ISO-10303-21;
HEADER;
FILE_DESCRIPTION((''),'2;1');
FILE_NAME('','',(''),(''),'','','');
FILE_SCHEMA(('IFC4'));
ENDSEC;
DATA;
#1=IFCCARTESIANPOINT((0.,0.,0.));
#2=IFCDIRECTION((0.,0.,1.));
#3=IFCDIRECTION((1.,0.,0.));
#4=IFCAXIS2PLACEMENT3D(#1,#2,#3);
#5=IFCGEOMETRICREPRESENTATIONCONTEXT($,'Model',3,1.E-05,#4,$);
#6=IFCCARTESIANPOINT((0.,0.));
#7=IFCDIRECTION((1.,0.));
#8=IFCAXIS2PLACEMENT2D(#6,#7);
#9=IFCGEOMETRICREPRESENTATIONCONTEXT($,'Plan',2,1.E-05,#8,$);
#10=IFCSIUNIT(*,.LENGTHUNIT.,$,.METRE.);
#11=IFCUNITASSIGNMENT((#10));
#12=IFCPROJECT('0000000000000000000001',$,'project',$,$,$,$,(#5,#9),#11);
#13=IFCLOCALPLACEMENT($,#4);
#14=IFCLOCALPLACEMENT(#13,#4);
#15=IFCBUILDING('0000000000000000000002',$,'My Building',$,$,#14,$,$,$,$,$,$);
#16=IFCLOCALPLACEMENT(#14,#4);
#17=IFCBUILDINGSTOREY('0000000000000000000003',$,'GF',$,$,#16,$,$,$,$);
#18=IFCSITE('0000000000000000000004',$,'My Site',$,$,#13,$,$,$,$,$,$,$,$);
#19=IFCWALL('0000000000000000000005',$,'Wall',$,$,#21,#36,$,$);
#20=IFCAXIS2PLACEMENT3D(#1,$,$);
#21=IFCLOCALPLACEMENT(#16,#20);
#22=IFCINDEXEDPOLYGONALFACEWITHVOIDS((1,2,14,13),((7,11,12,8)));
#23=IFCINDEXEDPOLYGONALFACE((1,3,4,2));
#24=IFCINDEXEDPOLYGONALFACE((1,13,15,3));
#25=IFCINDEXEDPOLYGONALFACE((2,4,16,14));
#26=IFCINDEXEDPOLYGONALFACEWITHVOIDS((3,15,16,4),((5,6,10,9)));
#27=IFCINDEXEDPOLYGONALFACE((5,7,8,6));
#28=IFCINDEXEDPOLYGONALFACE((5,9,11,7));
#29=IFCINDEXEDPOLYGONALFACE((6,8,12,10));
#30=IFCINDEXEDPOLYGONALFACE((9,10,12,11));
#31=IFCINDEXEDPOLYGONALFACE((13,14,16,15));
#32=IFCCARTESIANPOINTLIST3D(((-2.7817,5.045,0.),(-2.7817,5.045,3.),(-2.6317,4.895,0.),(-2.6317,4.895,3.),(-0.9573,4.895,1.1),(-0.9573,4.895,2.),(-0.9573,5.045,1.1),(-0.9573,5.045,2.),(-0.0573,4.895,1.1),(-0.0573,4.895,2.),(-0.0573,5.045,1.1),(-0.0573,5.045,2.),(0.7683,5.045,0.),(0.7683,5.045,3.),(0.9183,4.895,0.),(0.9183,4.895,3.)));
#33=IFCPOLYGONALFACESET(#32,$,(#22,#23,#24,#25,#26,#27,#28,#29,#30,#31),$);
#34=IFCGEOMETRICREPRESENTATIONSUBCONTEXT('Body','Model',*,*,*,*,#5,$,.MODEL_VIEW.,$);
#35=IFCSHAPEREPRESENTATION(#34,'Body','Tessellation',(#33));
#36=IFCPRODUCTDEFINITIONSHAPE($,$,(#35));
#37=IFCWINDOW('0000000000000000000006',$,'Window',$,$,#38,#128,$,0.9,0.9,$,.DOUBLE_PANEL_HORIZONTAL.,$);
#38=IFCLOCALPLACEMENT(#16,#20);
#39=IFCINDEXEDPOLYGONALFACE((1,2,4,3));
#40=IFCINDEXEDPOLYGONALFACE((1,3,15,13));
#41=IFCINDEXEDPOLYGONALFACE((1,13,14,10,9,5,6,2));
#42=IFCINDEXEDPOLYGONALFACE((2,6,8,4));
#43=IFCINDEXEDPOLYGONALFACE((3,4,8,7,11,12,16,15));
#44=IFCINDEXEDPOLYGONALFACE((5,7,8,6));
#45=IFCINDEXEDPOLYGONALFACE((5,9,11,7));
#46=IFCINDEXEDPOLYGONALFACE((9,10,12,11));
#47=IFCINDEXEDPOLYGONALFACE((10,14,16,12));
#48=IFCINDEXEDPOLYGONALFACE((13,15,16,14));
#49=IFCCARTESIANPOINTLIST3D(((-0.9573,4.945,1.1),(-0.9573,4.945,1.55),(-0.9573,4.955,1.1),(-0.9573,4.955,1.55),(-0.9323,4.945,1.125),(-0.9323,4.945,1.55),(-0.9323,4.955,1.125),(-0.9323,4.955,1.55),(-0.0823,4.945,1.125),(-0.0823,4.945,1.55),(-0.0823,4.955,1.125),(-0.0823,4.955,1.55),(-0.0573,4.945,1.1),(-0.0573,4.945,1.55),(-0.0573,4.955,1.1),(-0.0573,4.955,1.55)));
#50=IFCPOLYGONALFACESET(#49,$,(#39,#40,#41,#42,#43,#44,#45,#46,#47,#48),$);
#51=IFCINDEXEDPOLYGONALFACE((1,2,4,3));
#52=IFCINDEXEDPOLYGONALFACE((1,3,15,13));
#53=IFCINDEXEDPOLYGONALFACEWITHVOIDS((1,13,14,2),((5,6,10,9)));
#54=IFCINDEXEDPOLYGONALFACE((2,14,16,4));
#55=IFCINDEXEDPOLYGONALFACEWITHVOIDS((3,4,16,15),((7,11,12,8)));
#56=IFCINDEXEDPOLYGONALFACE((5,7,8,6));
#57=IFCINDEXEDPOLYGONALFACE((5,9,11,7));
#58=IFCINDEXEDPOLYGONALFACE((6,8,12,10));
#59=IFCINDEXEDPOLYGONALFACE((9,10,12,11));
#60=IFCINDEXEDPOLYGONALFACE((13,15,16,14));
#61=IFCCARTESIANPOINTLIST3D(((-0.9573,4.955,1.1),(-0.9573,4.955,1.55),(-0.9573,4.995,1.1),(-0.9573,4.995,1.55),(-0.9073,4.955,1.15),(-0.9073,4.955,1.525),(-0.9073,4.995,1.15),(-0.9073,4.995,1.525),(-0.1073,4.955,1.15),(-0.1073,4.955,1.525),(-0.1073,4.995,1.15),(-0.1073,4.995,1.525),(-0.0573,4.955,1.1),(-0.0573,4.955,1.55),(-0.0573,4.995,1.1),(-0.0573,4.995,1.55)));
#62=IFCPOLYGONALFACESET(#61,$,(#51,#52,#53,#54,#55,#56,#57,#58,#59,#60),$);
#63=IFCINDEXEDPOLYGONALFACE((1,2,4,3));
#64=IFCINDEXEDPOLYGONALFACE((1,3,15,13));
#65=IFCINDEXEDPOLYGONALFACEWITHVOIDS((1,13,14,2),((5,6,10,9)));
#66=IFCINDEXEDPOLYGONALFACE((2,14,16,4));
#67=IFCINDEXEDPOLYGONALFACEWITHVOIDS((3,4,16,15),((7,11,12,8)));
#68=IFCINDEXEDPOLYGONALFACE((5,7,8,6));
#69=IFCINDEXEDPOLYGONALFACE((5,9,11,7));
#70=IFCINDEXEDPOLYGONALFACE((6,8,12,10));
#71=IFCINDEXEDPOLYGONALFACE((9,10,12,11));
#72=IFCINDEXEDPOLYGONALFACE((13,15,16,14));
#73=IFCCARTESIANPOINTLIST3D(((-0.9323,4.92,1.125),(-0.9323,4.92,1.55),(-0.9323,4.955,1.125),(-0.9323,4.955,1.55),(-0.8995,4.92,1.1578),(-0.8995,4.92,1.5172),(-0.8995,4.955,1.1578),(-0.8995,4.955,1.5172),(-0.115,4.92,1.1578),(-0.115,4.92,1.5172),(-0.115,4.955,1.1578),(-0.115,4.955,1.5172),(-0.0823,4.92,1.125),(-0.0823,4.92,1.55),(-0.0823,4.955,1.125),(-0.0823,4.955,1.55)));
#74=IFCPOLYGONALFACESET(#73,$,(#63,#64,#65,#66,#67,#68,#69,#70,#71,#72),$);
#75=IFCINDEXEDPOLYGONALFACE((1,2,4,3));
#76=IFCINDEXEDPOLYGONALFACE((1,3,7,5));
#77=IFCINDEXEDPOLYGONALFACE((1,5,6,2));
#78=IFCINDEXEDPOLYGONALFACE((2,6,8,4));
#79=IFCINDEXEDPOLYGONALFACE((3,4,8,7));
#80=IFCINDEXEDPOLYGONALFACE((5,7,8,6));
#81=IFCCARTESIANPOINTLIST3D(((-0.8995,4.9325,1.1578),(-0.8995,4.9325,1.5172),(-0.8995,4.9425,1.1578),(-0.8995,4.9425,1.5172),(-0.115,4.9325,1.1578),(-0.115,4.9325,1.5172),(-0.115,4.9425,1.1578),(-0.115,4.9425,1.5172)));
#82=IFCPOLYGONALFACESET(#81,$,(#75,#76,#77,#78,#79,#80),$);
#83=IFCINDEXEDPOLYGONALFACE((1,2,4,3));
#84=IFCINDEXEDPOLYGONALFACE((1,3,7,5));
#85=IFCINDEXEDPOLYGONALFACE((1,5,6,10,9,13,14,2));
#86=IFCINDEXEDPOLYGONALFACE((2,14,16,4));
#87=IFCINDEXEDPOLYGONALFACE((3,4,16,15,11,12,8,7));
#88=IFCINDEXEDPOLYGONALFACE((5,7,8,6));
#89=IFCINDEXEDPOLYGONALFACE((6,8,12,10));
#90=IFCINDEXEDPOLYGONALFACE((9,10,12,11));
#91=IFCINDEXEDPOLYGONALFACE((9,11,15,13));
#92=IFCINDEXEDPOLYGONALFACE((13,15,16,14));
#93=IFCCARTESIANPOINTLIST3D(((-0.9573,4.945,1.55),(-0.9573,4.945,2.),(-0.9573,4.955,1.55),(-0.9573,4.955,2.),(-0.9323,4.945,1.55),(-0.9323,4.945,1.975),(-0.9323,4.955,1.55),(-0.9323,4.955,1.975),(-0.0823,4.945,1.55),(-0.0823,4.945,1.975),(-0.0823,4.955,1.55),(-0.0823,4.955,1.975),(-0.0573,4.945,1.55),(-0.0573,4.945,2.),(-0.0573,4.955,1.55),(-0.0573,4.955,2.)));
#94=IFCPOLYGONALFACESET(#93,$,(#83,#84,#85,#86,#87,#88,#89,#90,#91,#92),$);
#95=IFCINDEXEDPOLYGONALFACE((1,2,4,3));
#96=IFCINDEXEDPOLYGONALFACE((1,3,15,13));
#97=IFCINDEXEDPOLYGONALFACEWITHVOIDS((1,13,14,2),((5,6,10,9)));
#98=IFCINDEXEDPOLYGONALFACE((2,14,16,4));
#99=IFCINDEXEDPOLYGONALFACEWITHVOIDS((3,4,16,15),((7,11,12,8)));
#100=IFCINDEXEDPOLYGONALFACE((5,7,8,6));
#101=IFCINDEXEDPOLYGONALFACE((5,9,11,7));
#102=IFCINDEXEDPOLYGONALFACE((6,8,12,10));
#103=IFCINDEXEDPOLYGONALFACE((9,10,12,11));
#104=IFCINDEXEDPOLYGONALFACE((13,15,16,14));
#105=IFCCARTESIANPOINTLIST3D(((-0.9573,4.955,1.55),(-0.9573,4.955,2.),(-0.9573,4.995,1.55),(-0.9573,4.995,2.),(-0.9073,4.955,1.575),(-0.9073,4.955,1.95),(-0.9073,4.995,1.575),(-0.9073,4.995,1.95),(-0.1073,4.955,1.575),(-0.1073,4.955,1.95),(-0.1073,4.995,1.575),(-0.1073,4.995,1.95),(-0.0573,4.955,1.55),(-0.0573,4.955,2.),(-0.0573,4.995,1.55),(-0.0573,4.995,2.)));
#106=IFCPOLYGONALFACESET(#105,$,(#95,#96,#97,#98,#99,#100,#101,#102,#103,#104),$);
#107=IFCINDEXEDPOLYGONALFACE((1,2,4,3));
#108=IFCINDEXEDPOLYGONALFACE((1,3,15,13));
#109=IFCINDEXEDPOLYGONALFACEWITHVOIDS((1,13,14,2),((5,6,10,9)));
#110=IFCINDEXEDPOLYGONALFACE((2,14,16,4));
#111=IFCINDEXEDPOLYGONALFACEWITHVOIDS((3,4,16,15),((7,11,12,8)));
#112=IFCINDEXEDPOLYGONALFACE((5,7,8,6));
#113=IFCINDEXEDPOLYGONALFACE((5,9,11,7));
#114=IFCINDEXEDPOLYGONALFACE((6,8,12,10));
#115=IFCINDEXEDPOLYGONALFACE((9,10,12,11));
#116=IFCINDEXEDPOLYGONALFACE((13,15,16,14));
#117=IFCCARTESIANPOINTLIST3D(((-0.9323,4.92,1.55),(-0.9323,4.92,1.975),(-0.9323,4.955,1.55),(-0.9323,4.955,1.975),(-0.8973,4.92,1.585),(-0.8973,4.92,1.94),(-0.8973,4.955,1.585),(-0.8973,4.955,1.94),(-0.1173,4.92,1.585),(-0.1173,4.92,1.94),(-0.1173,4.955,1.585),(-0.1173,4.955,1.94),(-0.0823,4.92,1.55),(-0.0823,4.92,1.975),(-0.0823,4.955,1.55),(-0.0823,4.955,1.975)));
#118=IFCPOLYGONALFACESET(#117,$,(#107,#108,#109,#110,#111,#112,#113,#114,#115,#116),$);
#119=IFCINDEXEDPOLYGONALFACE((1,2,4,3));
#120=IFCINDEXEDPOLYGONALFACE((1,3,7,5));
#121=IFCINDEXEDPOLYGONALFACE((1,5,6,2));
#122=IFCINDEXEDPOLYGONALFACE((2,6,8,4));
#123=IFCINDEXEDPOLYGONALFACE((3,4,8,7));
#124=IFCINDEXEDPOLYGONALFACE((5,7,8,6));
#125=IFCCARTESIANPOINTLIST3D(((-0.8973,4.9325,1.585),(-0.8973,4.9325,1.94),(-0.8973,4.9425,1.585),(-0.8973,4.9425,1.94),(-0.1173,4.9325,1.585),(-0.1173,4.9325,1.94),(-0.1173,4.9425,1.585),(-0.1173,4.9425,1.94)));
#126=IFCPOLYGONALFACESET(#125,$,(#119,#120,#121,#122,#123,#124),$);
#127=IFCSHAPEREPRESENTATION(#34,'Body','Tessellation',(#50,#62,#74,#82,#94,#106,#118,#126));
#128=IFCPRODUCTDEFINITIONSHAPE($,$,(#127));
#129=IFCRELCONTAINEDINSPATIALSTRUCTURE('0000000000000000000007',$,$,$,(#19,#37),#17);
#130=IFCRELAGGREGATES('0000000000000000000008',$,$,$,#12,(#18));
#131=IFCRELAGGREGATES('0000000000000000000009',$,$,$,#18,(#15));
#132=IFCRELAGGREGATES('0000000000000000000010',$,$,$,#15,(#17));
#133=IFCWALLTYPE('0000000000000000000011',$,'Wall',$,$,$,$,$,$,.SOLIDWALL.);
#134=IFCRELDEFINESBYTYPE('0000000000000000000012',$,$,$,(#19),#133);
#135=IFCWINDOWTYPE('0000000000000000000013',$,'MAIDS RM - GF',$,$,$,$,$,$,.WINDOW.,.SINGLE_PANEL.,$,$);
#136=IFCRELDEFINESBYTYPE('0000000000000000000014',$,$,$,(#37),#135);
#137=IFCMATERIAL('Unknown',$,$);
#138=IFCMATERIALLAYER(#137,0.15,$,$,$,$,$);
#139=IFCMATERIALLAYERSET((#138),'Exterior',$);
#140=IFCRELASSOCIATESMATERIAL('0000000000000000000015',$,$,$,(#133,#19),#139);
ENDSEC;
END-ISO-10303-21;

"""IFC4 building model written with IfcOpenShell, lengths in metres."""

from ifc_helpers import new_model, entity, si_unit, frame, origin_with_axes, origin_2d_with_axis, place, context, subcontext, project, spatial, line, indexed_curve, outline, extrude, shape, source, transform, mapped, material, layer, layer_set, layer_usage, type_object, type_shapes, element, fill, save


model = new_model("IFC4")

# Units and contexts
model_context = context("Model", 3, precision=1e-05, world=origin_with_axes())
plan_context = context("Plan", 2, precision=1e-05, world=origin_2d_with_axis())
body_context_1 = subcontext(model_context, "Body", "Model", "MODEL_VIEW")
body_context_2 = subcontext(plan_context, "Body", "Plan", "PLAN_VIEW")
ifc_project = project(units=[si_unit("LENGTHUNIT", "METRE")], contexts=[model_context, plan_context])

# Site, building, storey
site_placement = place(None, origin_with_axes())
site = spatial("IfcSite", under=ifc_project, at=site_placement, Name="My Site")
building_placement = place(site_placement, origin_with_axes())
building = spatial("IfcBuilding", under=site, at=building_placement, Name="My Building")
storey_placement = place(building_placement, origin_with_axes())
storey = spatial("IfcBuildingStorey", under=building, at=storey_placement, Name="GF")

# Shared definitions
ifc_material = material(Name="Unknown")

# Shared definitions
ifc_layer_1 = layer(ifc_material, 0.15)
ifc_layer_set_1 = layer_set([ifc_layer_1], Name="Exterior")
wall_type_1 = type_object("IfcWallType", Name="Wall", PredefinedType="SOLIDWALL", material=ifc_layer_set_1)

# Wall, opening, window
ifc_layer_usage_1 = layer_usage(ifc_layer_set_1, "AXIS2", "POSITIVE", 0.0)
wall_1_placement = place(storey_placement, frame((0.7683, 5.045, 0.0), z_axis=(0.0, 0.0, 1.0), x_axis=(-1.0, 0.0, 0.0)))
wall_1 = element("IfcWall", 1, at=wall_1_placement, inside=storey, type_object=wall_type_1, material=ifc_layer_usage_1, Name="Wall", context=body_context_1, shape_type="SweptSolid", body=[
    extrude(outline(indexed_curve([(0.0, 0.0), (-0.15, 0.15), (3.4, 0.15), (3.55, 0.0)], segments=[line(1, 2, 3, 4, 1)])), origin_with_axes(), (0.0, 0.0, 1.0), 3.0),
])
shared_shape_1 = source(origin_with_axes(), body_context_1, "Body", "SweptSolid", [
    extrude(outline(indexed_curve([(0.0, 0.0), (0.9, 0.0), (0.9, 0.9), (0.0, 0.9)], segments=[line(1, 2, 3, 4, 1)])), frame((0.0, -0.6, 0.0), z_axis=(0.0, -1.0, 0.0), x_axis=(1.0, 0.0, 0.0)), (0.0, 0.0, -1.0), 1.2),
])
opening_1_placement = place(wall_1_placement, frame((0.8256, 0.0, 1.1), z_axis=(0.0, 0.0, 1.0), x_axis=(1.0, 0.0, 0.0)))
opening_1 = element("IfcOpeningElement", 2, at=opening_1_placement, cuts=wall_1, PredefinedType="OPENING", context=body_context_1, shape_type="MappedRepresentation", body=[
    mapped(shared_shape_1, transform((0.0, 0.0, 0.0), x_axis=(1.0, 0.0, 0.0), y_axis=(0.0, 1.0, 0.0), z_axis=(0.0, 0.0, 1.0), scale=1.0)),
])
window_type_1 = type_object("IfcWindowType", Name="MAIDS RM - GF", PartitioningType="SINGLE_PANEL", PredefinedType="WINDOW")
shared_shape_2 = source(origin_with_axes(), body_context_1, "Body", "SweptSolid", [
    extrude(outline(indexed_curve([(0.9, 0.45), (0.9, 0.0), (0.0, 0.0), (0.0, 0.45), (0.025, 0.45), (0.025, 0.025), (0.875, 0.025), (0.875, 0.45)], segments=[line(1, 2, 3, 4, 5, 6, 7, 8, 1)])), frame((0.0, 0.09, 0.0), z_axis=(0.0, -1.0, 0.0), x_axis=(1.0, 0.0, 0.0)), (0.0, 0.0, -1.0), 0.01),
    extrude(outline(indexed_curve([(0.0, 0.0), (0.9, 0.0), (0.9, 0.45), (0.0, 0.45)], segments=[line(1, 2, 3, 4, 1)]), holes=[indexed_curve([(0.05, 0.05), (0.85, 0.05), (0.85, 0.425), (0.05, 0.425)], segments=[line(1, 2, 3, 4, 1)])]), frame((0.0, 0.05, 0.0), z_axis=(0.0, -1.0, 0.0), x_axis=(1.0, 0.0, 0.0)), (0.0, 0.0, -1.0), 0.04),
    extrude(outline(indexed_curve([(0.0, 0.0), (0.85, 0.0), (0.85, 0.425), (0.0, 0.425)], segments=[line(1, 2, 3, 4, 1)]), holes=[indexed_curve([(0.0328, 0.0328), (0.8172, 0.0328), (0.8172, 0.3922), (0.0328, 0.3922)], segments=[line(1, 2, 3, 4, 1)])]), frame((0.025, 0.09, 0.025), z_axis=(0.0, -1.0, 0.0), x_axis=(1.0, 0.0, 0.0)), (0.0, 0.0, -1.0), 0.035),
    extrude(outline(indexed_curve([(0.0328, 0.0328), (0.8172, 0.0328), (0.8172, 0.3922), (0.0328, 0.3922)], segments=[line(1, 2, 3, 4, 1)])), frame((0.025, 0.1025, 0.025), z_axis=(0.0, -1.0, 0.0), x_axis=(1.0, 0.0, 0.0)), (0.0, 0.0, -1.0), 0.01),
    extrude(outline(indexed_curve([(0.0, 0.0), (0.0, 0.45), (0.9, 0.45), (0.9, 0.0), (0.875, 0.0), (0.875, 0.425), (0.025, 0.425), (0.025, 0.0)], segments=[line(1, 2, 3, 4, 5, 6, 7, 8, 1)])), frame((0.0, 0.09, 0.45), z_axis=(0.0, -1.0, 0.0), x_axis=(1.0, 0.0, 0.0)), (0.0, 0.0, -1.0), 0.01),
    extrude(outline(indexed_curve([(0.0, 0.0), (0.9, 0.0), (0.9, 0.45), (0.0, 0.45)], segments=[line(1, 2, 3, 4, 1)]), holes=[indexed_curve([(0.05, 0.025), (0.85, 0.025), (0.85, 0.4), (0.05, 0.4)], segments=[line(1, 2, 3, 4, 1)])]), frame((0.0, 0.05, 0.45), z_axis=(0.0, -1.0, 0.0), x_axis=(1.0, 0.0, 0.0)), (0.0, 0.0, -1.0), 0.04),
    extrude(outline(indexed_curve([(0.0, 0.0), (0.85, 0.0), (0.85, 0.425), (0.0, 0.425)], segments=[line(1, 2, 3, 4, 1)]), holes=[indexed_curve([(0.035, 0.035), (0.815, 0.035), (0.815, 0.39), (0.035, 0.39)], segments=[line(1, 2, 3, 4, 1)])]), frame((0.025, 0.09, 0.45), z_axis=(0.0, -1.0, 0.0), x_axis=(1.0, 0.0, 0.0)), (0.0, 0.0, -1.0), 0.035),
    extrude(outline(indexed_curve([(0.035, 0.035), (0.815, 0.035), (0.815, 0.39), (0.035, 0.39)], segments=[line(1, 2, 3, 4, 1)])), frame((0.025, 0.1025, 0.45), z_axis=(0.0, -1.0, 0.0), x_axis=(1.0, 0.0, 0.0)), (0.0, 0.0, -1.0), 0.01),
])
shared_shape_3 = source(origin_with_axes(), body_context_2, "Body", "Curve2D", [
    entity("IfcIndexedPolyCurve", entity("IfcCartesianPointList2D", [[0.05, 0.05], [0.85, 0.05]])),
    entity("IfcIndexedPolyCurve", entity("IfcCartesianPointList2D", [[0.0, 0.1], [0.025, 0.1], [0.025, 0.09], [0.05, 0.09], [0.05, 0.05], [0.0, 0.05]]), [entity("IfcLineIndex", [1, 2, 3, 4, 5, 6, 1])]),
    entity("IfcIndexedPolyCurve", entity("IfcCartesianPointList2D", [[0.9, 0.1], [0.875, 0.1], [0.875, 0.09], [0.85, 0.09], [0.85, 0.05], [0.9, 0.05]]), [entity("IfcLineIndex", [1, 2, 3, 4, 5, 6, 1])]),
    entity("IfcIndexedPolyCurve", entity("IfcCartesianPointList2D", [[0.025, 0.09], [0.06, 0.09], [0.06, 0.125], [0.025, 0.125]]), [entity("IfcLineIndex", [1, 2, 3, 4, 1])]),
    entity("IfcIndexedPolyCurve", entity("IfcCartesianPointList2D", [[0.875, 0.09], [0.84, 0.09], [0.84, 0.125], [0.875, 0.125]]), [entity("IfcLineIndex", [1, 2, 3, 4, 1])]),
    entity("IfcIndexedPolyCurve", entity("IfcCartesianPointList2D", [[0.06, 0.09], [0.84, 0.09]])),
    entity("IfcIndexedPolyCurve", entity("IfcCartesianPointList2D", [[0.06, 0.125], [0.84, 0.125]])),
    entity("IfcIndexedPolyCurve", entity("IfcCartesianPointList2D", [[0.06, 0.1075], [0.84, 0.1075]])),
])
type_shapes(window_type_1, [shared_shape_2, shared_shape_3])
window_1_placement = place(opening_1_placement, frame((0.0, 0.0, 0.0), z_axis=(0.0, 0.0, 1.0), x_axis=(1.0, 0.0, 0.0)))
window_1 = element("IfcWindow", 3, at=window_1_placement, inside=storey, type_object=window_type_1, Name="Window", OverallHeight=0.9, OverallWidth=0.9, PartitioningType="DOUBLE_PANEL_HORIZONTAL", shapes=[
    shape(body_context_1, "Body", "MappedRepresentation", [mapped(shared_shape_2, transform((0.0, 0.0, 0.0), x_axis=(1.0, 0.0, 0.0), y_axis=(0.0, 1.0, 0.0), z_axis=(0.0, 0.0, 1.0), scale=1.0))]),
    shape(body_context_2, "Body", "MappedRepresentation", [mapped(shared_shape_3, transform((0.0, 0.0, 0.0), x_axis=(1.0, 0.0, 0.0), y_axis=(0.0, 1.0, 0.0), z_axis=(0.0, 0.0, 1.0), scale=1.0))]),
])
fill(opening_1, window_1)

save(model, "model.ifc")
